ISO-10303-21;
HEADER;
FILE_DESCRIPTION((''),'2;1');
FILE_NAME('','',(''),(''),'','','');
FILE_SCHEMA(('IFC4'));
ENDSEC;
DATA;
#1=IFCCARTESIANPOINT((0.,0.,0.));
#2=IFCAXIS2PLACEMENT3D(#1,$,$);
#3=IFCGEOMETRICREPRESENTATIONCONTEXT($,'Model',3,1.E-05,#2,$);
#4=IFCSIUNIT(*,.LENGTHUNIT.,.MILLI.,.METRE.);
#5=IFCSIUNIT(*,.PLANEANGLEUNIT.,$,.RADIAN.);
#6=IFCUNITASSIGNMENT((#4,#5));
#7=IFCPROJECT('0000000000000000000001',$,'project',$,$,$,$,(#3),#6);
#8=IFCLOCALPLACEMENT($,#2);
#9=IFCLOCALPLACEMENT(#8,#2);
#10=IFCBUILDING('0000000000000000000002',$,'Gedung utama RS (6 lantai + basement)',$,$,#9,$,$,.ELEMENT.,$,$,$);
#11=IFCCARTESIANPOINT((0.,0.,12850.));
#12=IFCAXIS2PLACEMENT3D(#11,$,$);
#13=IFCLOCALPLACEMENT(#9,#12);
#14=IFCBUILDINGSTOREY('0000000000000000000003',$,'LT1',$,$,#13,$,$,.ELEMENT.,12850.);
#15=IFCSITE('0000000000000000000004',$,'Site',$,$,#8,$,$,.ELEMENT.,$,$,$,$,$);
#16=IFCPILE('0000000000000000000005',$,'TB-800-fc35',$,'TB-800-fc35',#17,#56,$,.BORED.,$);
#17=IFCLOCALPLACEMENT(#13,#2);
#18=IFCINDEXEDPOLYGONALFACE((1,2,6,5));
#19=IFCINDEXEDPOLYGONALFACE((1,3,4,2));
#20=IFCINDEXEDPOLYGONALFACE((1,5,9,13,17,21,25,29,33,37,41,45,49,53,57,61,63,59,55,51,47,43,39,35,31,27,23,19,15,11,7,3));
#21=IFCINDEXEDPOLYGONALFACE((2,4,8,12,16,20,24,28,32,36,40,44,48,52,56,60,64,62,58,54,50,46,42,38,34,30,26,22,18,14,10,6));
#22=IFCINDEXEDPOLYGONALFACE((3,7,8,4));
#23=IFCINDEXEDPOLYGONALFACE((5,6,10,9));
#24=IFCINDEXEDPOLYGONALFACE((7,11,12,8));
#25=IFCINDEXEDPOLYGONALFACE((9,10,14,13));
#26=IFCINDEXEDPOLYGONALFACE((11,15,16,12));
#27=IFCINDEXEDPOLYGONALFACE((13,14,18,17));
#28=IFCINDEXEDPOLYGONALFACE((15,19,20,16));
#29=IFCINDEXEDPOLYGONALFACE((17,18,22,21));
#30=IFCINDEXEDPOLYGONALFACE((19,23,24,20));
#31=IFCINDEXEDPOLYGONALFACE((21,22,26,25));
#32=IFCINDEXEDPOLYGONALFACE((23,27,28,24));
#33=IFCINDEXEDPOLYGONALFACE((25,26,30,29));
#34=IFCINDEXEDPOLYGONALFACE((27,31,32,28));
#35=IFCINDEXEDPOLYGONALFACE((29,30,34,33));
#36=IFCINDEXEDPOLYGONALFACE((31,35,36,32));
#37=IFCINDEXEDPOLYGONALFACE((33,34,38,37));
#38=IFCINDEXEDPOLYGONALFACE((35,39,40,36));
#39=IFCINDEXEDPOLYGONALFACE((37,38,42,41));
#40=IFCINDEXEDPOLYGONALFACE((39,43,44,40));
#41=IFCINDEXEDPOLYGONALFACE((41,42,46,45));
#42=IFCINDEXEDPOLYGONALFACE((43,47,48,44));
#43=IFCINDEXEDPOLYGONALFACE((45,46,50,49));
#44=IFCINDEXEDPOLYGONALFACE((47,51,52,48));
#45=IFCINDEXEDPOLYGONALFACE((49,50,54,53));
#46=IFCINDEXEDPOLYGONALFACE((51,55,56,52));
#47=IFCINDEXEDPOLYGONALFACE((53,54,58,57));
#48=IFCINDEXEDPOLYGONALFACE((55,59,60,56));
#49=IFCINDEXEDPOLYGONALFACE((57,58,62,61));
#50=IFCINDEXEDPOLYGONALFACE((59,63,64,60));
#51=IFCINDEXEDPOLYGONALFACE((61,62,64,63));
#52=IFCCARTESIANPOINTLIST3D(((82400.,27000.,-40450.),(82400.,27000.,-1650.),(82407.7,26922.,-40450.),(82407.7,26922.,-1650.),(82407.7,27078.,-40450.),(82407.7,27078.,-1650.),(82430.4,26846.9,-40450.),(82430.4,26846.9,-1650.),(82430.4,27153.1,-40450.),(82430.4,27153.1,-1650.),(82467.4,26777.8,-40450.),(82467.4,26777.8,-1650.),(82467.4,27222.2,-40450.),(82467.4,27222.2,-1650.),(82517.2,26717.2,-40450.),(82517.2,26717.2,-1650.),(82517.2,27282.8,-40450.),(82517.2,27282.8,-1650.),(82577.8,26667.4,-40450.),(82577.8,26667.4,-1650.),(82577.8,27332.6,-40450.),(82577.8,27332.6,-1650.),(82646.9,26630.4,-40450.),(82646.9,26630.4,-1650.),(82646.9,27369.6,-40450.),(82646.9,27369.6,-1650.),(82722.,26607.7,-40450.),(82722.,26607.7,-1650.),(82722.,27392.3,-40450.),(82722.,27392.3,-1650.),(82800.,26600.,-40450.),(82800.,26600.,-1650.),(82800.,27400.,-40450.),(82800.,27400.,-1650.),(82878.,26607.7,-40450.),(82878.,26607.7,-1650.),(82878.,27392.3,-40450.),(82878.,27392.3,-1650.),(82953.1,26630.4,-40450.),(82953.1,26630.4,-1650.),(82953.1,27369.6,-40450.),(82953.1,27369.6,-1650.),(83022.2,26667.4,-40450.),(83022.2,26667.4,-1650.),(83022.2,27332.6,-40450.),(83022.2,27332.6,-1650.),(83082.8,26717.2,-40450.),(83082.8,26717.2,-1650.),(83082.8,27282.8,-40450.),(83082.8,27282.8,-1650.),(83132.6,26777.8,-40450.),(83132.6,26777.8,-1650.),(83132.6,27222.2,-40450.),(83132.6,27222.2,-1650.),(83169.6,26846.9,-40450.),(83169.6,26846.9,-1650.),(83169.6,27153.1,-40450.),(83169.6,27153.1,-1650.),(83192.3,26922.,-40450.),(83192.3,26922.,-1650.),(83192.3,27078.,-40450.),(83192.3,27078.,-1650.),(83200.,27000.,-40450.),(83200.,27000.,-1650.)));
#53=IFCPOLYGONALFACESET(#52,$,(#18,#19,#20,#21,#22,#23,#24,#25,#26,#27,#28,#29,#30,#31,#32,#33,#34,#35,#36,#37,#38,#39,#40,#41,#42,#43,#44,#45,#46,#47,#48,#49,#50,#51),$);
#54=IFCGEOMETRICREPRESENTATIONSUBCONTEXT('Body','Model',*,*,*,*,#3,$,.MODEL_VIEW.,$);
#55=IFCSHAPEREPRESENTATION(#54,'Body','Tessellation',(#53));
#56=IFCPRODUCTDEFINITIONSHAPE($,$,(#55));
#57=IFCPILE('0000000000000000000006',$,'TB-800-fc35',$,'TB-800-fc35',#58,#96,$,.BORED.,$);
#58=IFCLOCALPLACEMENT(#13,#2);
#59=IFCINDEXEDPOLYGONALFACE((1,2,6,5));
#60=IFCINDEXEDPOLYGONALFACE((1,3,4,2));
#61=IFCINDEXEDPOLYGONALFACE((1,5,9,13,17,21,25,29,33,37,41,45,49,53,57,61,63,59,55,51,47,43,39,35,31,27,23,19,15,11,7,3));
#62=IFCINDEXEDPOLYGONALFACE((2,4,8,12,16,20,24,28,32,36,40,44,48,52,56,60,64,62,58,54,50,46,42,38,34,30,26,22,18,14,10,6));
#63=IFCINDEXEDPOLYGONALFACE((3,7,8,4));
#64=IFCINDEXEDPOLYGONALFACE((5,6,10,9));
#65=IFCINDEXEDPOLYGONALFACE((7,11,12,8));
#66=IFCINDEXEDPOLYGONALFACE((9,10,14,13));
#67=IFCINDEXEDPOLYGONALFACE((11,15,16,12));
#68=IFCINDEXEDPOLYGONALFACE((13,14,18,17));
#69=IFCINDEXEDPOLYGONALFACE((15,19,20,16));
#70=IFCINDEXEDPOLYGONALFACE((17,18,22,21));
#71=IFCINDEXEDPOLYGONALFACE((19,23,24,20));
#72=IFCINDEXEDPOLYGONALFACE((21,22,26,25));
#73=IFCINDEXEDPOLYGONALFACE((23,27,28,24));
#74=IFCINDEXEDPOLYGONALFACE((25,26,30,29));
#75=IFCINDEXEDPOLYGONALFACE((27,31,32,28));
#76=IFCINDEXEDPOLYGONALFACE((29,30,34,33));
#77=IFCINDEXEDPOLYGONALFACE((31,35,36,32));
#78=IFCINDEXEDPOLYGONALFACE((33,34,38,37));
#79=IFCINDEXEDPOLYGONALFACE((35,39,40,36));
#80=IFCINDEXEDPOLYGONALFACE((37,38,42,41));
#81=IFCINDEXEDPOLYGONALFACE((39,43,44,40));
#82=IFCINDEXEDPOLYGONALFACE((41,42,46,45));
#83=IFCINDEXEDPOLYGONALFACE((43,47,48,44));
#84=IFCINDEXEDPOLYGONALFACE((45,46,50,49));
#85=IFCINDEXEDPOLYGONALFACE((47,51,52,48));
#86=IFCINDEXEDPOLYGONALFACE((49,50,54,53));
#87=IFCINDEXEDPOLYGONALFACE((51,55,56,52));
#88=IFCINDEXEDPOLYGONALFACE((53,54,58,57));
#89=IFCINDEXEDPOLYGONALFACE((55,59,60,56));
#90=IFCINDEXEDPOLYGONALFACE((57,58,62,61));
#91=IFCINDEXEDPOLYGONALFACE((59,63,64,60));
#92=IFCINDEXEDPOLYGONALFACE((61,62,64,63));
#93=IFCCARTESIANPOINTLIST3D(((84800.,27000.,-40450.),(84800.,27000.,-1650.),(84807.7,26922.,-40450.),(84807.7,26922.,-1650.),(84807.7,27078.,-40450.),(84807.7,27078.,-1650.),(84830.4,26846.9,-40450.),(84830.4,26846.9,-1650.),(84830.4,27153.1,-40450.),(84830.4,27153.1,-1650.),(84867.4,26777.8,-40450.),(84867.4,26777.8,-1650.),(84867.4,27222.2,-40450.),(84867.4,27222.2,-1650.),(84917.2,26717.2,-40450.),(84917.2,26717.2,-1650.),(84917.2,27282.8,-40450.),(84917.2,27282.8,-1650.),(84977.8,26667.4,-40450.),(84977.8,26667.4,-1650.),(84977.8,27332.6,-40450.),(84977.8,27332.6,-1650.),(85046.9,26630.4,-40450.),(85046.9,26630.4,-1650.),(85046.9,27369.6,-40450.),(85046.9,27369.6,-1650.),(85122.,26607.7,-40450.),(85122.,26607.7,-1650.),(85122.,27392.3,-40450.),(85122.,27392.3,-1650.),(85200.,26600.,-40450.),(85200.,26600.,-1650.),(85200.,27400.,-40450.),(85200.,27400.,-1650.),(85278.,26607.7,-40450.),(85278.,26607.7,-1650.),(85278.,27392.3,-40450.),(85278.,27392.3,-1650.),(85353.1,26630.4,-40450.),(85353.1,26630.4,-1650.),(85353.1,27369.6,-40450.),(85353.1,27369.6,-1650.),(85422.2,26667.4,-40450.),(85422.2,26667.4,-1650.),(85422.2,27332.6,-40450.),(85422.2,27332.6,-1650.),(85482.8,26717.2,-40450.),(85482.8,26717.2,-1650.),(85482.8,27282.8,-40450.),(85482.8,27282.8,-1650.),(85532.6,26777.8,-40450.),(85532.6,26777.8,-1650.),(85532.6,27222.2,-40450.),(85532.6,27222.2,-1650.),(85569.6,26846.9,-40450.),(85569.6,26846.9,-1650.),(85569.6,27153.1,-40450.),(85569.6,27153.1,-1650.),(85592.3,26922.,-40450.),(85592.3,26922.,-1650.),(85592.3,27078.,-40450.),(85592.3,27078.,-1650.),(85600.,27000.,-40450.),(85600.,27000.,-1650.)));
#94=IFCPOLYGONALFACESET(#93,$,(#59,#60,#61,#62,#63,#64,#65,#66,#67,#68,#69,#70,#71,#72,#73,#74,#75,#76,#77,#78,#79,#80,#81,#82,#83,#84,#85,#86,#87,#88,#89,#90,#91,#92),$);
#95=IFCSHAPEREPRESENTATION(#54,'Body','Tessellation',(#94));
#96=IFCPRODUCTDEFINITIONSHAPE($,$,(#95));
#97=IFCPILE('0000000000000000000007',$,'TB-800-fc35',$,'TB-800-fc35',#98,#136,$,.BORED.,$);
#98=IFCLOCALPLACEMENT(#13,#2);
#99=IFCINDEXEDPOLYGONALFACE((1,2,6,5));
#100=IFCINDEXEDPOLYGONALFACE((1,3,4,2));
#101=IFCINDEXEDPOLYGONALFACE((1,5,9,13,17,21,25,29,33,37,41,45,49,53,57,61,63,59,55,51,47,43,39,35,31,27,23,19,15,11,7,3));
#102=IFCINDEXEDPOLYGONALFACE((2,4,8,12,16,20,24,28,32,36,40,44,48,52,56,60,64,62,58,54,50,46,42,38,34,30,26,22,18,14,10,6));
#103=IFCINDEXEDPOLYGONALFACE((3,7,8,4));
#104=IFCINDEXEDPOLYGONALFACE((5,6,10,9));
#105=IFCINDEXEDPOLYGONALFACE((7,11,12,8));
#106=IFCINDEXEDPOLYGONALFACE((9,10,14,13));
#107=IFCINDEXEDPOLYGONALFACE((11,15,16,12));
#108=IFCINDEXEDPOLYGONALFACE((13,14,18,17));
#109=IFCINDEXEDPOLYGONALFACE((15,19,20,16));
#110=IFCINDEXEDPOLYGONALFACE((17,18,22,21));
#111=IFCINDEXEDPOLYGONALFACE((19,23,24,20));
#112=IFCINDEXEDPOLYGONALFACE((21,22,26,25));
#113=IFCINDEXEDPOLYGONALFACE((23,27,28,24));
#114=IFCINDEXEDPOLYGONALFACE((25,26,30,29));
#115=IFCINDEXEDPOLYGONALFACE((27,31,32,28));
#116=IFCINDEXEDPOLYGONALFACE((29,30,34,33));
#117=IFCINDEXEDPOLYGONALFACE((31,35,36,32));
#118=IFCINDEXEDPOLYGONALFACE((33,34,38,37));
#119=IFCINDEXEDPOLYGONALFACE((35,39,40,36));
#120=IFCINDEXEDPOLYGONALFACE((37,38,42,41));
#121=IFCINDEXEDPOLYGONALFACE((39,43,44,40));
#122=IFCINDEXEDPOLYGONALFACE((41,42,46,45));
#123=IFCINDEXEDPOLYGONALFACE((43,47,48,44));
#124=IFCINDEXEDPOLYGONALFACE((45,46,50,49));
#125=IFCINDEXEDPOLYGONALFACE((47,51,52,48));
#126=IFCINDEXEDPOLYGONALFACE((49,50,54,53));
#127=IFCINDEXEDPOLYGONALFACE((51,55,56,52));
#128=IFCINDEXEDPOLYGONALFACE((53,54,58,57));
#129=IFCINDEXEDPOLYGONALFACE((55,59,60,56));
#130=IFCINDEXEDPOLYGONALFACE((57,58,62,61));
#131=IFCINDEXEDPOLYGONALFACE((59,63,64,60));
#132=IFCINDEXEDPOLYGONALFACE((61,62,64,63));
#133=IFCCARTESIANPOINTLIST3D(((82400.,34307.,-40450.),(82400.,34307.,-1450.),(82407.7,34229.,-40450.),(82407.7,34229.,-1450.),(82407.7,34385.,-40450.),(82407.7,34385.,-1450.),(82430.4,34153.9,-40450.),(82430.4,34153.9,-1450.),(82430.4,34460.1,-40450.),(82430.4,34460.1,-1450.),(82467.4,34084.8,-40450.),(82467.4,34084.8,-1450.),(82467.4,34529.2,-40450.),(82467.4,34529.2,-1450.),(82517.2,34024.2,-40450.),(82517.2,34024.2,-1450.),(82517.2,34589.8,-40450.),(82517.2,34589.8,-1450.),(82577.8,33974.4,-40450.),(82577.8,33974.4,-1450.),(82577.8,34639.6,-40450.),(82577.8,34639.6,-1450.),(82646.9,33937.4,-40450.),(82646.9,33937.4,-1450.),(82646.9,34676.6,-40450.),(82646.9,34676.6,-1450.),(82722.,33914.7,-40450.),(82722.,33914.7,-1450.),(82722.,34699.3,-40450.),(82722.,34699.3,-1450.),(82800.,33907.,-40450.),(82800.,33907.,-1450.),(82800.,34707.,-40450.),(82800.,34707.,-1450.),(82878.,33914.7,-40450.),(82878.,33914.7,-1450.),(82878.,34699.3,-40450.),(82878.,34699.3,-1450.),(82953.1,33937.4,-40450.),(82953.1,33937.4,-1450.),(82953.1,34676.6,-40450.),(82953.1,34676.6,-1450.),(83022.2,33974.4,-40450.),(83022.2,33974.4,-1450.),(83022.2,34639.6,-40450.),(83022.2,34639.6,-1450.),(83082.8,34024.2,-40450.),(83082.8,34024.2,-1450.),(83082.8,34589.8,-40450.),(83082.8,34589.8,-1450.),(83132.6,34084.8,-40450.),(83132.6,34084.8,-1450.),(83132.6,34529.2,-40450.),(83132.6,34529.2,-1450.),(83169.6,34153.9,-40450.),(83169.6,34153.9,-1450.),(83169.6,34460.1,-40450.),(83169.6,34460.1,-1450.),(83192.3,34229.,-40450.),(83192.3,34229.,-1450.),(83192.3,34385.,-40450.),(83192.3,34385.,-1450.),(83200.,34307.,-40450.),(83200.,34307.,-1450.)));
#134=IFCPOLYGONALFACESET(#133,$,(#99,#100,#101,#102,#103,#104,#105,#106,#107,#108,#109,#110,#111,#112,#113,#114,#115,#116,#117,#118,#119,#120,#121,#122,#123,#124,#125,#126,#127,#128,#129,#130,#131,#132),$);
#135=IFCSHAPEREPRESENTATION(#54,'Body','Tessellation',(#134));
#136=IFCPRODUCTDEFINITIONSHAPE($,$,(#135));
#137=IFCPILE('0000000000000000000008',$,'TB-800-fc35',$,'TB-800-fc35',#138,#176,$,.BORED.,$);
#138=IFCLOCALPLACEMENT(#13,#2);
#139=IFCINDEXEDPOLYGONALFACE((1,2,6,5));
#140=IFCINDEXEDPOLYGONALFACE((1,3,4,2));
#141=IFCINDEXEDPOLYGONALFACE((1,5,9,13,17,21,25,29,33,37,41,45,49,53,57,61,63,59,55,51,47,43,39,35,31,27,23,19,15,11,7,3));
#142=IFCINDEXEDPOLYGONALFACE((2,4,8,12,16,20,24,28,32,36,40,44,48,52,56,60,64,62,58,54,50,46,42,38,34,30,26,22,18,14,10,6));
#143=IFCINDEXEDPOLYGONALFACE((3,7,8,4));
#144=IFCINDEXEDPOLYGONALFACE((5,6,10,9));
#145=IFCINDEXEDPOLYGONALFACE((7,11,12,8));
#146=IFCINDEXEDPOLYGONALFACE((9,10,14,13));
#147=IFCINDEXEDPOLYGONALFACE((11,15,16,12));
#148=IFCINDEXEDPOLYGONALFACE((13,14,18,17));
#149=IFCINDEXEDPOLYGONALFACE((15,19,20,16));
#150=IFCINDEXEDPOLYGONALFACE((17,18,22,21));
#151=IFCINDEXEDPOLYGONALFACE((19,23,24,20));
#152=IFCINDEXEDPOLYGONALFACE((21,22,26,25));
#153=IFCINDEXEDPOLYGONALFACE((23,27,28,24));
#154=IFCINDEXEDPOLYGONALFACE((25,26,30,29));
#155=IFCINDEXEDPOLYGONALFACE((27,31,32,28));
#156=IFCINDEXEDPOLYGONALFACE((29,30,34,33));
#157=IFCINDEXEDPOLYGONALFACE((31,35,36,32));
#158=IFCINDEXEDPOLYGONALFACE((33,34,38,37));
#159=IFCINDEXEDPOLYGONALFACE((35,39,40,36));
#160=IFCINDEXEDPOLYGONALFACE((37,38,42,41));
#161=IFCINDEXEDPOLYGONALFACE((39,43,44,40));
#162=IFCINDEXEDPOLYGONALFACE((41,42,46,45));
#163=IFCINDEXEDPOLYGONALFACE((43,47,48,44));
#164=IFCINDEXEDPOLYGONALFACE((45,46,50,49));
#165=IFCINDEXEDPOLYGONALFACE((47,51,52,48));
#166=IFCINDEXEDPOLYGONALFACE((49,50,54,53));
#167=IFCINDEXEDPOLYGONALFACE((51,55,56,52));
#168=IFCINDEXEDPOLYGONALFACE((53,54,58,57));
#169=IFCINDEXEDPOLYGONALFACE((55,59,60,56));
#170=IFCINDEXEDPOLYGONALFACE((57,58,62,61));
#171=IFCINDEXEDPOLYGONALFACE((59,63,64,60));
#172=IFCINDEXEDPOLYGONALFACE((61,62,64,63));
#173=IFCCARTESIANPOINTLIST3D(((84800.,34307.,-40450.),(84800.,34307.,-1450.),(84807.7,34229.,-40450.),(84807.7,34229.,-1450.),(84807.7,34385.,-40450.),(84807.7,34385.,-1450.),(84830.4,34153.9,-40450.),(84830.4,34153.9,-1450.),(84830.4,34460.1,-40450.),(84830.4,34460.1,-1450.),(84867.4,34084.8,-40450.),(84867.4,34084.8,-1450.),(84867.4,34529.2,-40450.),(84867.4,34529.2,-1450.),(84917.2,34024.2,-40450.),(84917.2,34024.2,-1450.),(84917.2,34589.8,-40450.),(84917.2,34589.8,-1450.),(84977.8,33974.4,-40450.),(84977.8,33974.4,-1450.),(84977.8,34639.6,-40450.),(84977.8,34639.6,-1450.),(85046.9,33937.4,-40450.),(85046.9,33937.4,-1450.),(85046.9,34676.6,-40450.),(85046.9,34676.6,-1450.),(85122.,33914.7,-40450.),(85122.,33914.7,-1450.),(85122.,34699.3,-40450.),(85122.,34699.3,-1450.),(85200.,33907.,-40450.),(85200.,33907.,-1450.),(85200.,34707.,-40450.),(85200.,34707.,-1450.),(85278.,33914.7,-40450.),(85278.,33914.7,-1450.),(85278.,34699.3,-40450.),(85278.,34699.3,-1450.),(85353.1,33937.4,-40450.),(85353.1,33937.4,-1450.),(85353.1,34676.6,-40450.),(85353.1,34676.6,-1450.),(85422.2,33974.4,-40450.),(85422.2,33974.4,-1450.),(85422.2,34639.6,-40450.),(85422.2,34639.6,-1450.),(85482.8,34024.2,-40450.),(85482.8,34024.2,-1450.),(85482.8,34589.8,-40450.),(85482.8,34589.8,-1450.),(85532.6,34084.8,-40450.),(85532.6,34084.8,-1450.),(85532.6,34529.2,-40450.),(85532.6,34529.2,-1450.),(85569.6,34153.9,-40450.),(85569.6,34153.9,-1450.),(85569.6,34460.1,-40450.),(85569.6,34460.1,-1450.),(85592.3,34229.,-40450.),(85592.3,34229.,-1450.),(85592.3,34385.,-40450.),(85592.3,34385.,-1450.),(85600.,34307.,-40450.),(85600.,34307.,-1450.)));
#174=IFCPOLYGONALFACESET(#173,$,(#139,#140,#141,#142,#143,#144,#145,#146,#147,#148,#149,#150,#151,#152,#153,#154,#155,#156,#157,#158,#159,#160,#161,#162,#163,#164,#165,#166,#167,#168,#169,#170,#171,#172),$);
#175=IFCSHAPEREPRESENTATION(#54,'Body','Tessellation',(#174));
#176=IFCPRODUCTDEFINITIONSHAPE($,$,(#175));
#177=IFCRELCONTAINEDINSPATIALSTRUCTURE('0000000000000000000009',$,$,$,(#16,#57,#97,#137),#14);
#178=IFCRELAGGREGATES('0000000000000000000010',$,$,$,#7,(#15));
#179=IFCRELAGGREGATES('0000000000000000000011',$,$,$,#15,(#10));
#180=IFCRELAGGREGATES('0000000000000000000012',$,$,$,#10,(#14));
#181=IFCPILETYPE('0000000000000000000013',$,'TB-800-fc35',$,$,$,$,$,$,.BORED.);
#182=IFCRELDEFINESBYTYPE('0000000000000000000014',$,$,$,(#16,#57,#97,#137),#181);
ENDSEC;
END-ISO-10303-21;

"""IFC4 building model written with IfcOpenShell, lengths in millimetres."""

from ifc_helpers import new_model, si_unit, frame, origin, origin_2d, place, context, subcontext, project, spatial, circle, extrude, material_profile, profile_set, profile_usage, type_object, element, save


model = new_model("IFC4")

# Units and contexts
model_context = context("Model", 3, precision=1e-05, world=origin())
body_context = subcontext(model_context, "Body", "Model", "MODEL_VIEW")
ifc_project = project(units=[si_unit("LENGTHUNIT", "METRE", prefix="MILLI"), si_unit("PLANEANGLEUNIT", "RADIAN")], contexts=[model_context])

# Site, building, storey
site_placement = place(None, origin())
site = spatial("IfcSite", under=ifc_project, at=site_placement, Name="Site", CompositionType="ELEMENT")
building_placement = place(site_placement, origin())
building = spatial("IfcBuilding", under=site, at=building_placement, Name="Gedung utama RS (6 lantai + basement)", CompositionType="ELEMENT")
storey_placement = place(building_placement, frame((0.0, 0.0, 12850.0)))
storey = spatial("IfcBuildingStorey", under=building, at=storey_placement, Name="LT1", CompositionType="ELEMENT", Elevation=12850.0)

# Piles
ifc_material_profile_1 = material_profile(None, circle(Radius=400.0, at=origin_2d()), Name="TB-800-fc35")
ifc_profile_set_1 = profile_set([ifc_material_profile_1], Name="TB-800-fc35")
ifc_profile_usage_1 = profile_usage(ifc_profile_set_1, cardinal=5)
pile_type = type_object("IfcPileType", Name="TB-800-fc35", PredefinedType="BORED", material=ifc_profile_set_1)
for number, where, z_axis, x_axis, name in (
    (1, (82800.0, 27000.0, -40450.0), (0.0, 0.0, 1.0), (1.0, 0.0, 0.0), "TB-800-fc35"),
    (2, (85200.0, 27000.0, -40450.0), (0.0, 0.0, 1.0), (1.0, 0.0, 0.0), "TB-800-fc35"),
):
    element("IfcPile", number, at=place(storey_placement, frame(where, z_axis=z_axis, x_axis=x_axis)), inside=storey, type_object=pile_type, material=ifc_profile_usage_1, Name=name, ObjectType="TB-800-fc35", PredefinedType="BORED", context=body_context, shape_type="SweptSolid", body=[
        extrude(circle(Radius=400.0, at=origin_2d()), origin(), (0.0, 0.0, 1.0), 38800.0),
    ])
for number, where, z_axis, x_axis, name in (
    (3, (82800.0, 34307.0, -40450.0), (0.0, 0.0, 1.0), (1.0, 0.0, 0.0), "TB-800-fc35"),
    (4, (85200.0, 34307.0, -40450.0), (0.0, 0.0, 1.0), (1.0, 0.0, 0.0), "TB-800-fc35"),
):
    element("IfcPile", number, at=place(storey_placement, frame(where, z_axis=z_axis, x_axis=x_axis)), inside=storey, type_object=pile_type, material=ifc_profile_usage_1, Name=name, ObjectType="TB-800-fc35", PredefinedType="BORED", context=body_context, shape_type="SweptSolid", body=[
        extrude(circle(Radius=400.0, at=origin_2d()), origin(), (0.0, 0.0, 1.0), 39000.0),
    ])

save(model, "model.ifc")
